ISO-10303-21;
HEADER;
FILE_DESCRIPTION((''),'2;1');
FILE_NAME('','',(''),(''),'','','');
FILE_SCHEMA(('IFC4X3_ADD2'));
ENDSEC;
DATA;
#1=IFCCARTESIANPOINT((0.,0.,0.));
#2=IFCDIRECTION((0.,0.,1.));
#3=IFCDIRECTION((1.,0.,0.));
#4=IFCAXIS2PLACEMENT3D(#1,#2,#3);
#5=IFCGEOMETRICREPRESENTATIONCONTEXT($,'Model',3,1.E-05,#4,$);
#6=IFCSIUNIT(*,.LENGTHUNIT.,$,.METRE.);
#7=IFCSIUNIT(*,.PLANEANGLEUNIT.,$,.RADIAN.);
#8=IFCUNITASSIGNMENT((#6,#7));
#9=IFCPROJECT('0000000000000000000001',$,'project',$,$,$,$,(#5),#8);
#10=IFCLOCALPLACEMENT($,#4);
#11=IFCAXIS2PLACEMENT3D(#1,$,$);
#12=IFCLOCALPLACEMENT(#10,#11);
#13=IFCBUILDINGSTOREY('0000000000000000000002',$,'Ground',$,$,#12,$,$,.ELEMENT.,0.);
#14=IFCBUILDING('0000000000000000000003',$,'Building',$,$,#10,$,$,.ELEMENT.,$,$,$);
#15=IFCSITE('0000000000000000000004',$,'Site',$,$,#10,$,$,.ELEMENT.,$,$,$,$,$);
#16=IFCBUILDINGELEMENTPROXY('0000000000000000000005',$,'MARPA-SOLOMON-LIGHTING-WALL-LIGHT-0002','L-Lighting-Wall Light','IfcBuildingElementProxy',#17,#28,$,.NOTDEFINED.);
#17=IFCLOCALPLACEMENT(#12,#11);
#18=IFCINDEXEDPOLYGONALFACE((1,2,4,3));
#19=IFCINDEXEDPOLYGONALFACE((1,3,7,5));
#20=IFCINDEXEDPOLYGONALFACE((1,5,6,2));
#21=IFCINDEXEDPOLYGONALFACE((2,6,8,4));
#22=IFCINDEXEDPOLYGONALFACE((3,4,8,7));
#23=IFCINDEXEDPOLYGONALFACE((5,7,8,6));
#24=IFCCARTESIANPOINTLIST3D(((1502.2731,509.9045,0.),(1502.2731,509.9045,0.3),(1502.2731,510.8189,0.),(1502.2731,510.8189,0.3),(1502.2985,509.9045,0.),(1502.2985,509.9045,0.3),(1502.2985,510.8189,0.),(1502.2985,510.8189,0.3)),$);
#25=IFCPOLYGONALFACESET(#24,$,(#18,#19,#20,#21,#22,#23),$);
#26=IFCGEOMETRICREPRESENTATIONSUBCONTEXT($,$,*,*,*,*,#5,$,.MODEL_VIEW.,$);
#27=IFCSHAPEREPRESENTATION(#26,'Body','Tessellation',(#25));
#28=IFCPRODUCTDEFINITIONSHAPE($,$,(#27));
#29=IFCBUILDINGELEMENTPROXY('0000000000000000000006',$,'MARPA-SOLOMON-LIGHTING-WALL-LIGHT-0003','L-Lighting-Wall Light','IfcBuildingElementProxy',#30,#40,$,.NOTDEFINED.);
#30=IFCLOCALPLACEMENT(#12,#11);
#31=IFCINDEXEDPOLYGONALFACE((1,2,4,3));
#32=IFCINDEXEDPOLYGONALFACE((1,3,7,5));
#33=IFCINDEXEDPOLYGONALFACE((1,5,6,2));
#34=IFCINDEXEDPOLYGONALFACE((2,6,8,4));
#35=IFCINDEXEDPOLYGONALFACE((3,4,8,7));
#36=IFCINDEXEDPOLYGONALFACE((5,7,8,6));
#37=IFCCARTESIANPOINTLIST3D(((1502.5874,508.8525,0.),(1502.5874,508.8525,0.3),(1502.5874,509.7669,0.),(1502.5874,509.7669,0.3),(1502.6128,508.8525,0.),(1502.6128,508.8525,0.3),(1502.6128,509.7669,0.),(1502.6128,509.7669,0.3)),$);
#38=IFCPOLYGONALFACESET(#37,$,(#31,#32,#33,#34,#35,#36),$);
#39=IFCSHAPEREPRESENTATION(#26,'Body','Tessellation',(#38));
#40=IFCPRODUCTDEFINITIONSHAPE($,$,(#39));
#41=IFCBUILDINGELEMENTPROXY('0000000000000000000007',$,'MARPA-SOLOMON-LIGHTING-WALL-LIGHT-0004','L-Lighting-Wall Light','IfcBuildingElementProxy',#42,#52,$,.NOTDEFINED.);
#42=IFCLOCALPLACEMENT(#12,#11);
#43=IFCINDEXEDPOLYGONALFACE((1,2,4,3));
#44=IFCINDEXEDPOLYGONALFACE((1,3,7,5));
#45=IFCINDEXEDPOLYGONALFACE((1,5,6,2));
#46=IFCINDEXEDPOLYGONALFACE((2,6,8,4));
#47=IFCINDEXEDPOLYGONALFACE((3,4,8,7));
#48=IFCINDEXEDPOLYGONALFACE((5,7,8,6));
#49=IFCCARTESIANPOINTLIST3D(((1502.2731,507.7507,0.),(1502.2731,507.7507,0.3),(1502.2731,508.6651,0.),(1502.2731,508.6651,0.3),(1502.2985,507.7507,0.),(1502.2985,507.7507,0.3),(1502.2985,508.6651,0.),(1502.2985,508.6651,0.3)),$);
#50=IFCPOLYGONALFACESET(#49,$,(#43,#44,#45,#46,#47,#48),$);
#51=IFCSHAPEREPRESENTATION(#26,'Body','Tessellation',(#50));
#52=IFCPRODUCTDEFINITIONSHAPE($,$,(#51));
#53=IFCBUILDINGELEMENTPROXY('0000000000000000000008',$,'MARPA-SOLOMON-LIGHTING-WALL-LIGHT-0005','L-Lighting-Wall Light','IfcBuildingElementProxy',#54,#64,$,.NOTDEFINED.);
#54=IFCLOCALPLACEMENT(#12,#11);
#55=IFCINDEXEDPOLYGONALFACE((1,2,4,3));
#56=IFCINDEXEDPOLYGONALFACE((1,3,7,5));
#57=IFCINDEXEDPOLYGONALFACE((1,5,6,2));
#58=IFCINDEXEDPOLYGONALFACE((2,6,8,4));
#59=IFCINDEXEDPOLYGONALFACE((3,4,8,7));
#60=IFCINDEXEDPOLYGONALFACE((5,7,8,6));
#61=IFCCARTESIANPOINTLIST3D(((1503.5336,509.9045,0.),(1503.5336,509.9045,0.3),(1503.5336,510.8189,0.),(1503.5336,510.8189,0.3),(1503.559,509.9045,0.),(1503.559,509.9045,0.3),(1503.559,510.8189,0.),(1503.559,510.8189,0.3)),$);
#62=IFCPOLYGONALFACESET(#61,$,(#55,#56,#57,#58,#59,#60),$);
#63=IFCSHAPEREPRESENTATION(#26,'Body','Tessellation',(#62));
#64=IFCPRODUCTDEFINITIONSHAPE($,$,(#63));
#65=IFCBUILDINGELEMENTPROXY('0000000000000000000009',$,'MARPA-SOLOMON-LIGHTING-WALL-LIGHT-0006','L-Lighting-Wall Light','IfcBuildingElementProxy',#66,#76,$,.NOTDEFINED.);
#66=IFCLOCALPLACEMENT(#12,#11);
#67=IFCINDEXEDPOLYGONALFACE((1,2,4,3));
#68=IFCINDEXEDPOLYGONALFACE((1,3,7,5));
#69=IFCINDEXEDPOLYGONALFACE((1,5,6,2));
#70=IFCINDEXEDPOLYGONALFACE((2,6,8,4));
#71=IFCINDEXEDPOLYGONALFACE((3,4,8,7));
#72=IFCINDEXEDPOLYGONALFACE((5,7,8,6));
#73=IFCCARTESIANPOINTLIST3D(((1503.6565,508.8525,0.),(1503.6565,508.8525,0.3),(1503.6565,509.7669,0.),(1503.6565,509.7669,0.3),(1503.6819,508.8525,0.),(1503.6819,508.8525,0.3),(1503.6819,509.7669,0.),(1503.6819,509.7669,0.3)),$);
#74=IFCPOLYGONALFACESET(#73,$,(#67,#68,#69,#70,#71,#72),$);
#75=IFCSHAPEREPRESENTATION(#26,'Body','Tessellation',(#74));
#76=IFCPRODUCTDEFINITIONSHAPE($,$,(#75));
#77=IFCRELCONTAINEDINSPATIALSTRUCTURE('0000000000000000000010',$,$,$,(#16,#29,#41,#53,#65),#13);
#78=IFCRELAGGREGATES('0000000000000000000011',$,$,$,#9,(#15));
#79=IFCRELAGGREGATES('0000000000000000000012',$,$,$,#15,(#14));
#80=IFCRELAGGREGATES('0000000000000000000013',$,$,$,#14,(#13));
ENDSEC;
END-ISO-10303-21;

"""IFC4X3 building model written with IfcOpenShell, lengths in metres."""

from ifc_helpers import new_model, si_unit, frame, origin, origin_with_axes, place, context, subcontext, project, spatial, polyline, outline, extrude, element, save


model = new_model("IFC4X3")

# Units and contexts
model_context = context("Model", 3, precision=1e-05, world=origin_with_axes())
sub_context = subcontext(model_context, None, None, "MODEL_VIEW")
ifc_project = project(units=[si_unit("LENGTHUNIT", "METRE"), si_unit("PLANEANGLEUNIT", "RADIAN")], contexts=[model_context])

# Site, building, storey
placement = place(None, origin_with_axes())
site = spatial("IfcSite", under=ifc_project, at=placement, Name="Site", CompositionType="ELEMENT")
building = spatial("IfcBuilding", under=site, at=placement, Name="Building", CompositionType="ELEMENT")
storey_placement = place(placement, origin())
storey = spatial("IfcBuildingStorey", under=building, at=storey_placement, Name="Ground", CompositionType="ELEMENT", Elevation=0.0)

# Building element proxies
proxy_1_placement = place(placement, frame((1502.2731, 509.9045, 0.0)))
element("IfcBuildingElementProxy", 1, at=proxy_1_placement, inside=storey, Name="MARPA-SOLOMON-LIGHTING-WALL-LIGHT-0002", Description="L-Lighting-Wall Light", ObjectType="IfcBuildingElementProxy", PredefinedType="NOTDEFINED", context=sub_context, shape_type="SweptSolid", body=[
    extrude(outline(polyline([(0.0254, 0.0), (0.0, 0.0), (0.0, 0.9144), (0.0254, 0.9144), (0.0254, 0.0)])), origin(), (0.0, 0.0, 1.0), 0.3),
])
for number, where, name in (
    (2, (1502.5874, 508.8525, 0.0), "MARPA-SOLOMON-LIGHTING-WALL-LIGHT-0003"),
    (3, (1502.2731, 507.7507, 0.0), "MARPA-SOLOMON-LIGHTING-WALL-LIGHT-0004"),
):
    element("IfcBuildingElementProxy", number, at=place(placement, frame(where)), inside=storey, Name=name, Description="L-Lighting-Wall Light", ObjectType="IfcBuildingElementProxy", PredefinedType="NOTDEFINED", context=sub_context, shape_type="SweptSolid", body=[
        extrude(outline(polyline([(0.0254, 0.0), (0.0, 0.0), (0.0, 0.9144), (0.0254, 0.9144), (0.0254, 0.0)])), origin(), (0.0, 0.0, 1.0), 0.3),
    ])
proxy_2_placement = place(placement, frame((1503.5336, 509.9045, 0.0)))
element("IfcBuildingElementProxy", 4, at=proxy_2_placement, inside=storey, Name="MARPA-SOLOMON-LIGHTING-WALL-LIGHT-0005", Description="L-Lighting-Wall Light", ObjectType="IfcBuildingElementProxy", PredefinedType="NOTDEFINED", context=sub_context, shape_type="SweptSolid", body=[
    extrude(outline(polyline([(0.0254, 0.0), (0.0, 0.0), (0.0, 0.9144), (0.0254, 0.9144), (0.0254, 0.0)])), origin(), (0.0, 0.0, 1.0), 0.3),
])
proxy_3_placement = place(placement, frame((1503.6565, 508.8525, 0.0)))
element("IfcBuildingElementProxy", 5, at=proxy_3_placement, inside=storey, Name="MARPA-SOLOMON-LIGHTING-WALL-LIGHT-0006", Description="L-Lighting-Wall Light", ObjectType="IfcBuildingElementProxy", PredefinedType="NOTDEFINED", context=sub_context, shape_type="SweptSolid", body=[
    extrude(outline(polyline([(0.0254, 0.0), (0.0, 0.0), (0.0, 0.9144), (0.0254, 0.9144), (0.0254, 0.0)])), origin(), (0.0, 0.0, 1.0), 0.3),
])

save(model, "model.ifc")
